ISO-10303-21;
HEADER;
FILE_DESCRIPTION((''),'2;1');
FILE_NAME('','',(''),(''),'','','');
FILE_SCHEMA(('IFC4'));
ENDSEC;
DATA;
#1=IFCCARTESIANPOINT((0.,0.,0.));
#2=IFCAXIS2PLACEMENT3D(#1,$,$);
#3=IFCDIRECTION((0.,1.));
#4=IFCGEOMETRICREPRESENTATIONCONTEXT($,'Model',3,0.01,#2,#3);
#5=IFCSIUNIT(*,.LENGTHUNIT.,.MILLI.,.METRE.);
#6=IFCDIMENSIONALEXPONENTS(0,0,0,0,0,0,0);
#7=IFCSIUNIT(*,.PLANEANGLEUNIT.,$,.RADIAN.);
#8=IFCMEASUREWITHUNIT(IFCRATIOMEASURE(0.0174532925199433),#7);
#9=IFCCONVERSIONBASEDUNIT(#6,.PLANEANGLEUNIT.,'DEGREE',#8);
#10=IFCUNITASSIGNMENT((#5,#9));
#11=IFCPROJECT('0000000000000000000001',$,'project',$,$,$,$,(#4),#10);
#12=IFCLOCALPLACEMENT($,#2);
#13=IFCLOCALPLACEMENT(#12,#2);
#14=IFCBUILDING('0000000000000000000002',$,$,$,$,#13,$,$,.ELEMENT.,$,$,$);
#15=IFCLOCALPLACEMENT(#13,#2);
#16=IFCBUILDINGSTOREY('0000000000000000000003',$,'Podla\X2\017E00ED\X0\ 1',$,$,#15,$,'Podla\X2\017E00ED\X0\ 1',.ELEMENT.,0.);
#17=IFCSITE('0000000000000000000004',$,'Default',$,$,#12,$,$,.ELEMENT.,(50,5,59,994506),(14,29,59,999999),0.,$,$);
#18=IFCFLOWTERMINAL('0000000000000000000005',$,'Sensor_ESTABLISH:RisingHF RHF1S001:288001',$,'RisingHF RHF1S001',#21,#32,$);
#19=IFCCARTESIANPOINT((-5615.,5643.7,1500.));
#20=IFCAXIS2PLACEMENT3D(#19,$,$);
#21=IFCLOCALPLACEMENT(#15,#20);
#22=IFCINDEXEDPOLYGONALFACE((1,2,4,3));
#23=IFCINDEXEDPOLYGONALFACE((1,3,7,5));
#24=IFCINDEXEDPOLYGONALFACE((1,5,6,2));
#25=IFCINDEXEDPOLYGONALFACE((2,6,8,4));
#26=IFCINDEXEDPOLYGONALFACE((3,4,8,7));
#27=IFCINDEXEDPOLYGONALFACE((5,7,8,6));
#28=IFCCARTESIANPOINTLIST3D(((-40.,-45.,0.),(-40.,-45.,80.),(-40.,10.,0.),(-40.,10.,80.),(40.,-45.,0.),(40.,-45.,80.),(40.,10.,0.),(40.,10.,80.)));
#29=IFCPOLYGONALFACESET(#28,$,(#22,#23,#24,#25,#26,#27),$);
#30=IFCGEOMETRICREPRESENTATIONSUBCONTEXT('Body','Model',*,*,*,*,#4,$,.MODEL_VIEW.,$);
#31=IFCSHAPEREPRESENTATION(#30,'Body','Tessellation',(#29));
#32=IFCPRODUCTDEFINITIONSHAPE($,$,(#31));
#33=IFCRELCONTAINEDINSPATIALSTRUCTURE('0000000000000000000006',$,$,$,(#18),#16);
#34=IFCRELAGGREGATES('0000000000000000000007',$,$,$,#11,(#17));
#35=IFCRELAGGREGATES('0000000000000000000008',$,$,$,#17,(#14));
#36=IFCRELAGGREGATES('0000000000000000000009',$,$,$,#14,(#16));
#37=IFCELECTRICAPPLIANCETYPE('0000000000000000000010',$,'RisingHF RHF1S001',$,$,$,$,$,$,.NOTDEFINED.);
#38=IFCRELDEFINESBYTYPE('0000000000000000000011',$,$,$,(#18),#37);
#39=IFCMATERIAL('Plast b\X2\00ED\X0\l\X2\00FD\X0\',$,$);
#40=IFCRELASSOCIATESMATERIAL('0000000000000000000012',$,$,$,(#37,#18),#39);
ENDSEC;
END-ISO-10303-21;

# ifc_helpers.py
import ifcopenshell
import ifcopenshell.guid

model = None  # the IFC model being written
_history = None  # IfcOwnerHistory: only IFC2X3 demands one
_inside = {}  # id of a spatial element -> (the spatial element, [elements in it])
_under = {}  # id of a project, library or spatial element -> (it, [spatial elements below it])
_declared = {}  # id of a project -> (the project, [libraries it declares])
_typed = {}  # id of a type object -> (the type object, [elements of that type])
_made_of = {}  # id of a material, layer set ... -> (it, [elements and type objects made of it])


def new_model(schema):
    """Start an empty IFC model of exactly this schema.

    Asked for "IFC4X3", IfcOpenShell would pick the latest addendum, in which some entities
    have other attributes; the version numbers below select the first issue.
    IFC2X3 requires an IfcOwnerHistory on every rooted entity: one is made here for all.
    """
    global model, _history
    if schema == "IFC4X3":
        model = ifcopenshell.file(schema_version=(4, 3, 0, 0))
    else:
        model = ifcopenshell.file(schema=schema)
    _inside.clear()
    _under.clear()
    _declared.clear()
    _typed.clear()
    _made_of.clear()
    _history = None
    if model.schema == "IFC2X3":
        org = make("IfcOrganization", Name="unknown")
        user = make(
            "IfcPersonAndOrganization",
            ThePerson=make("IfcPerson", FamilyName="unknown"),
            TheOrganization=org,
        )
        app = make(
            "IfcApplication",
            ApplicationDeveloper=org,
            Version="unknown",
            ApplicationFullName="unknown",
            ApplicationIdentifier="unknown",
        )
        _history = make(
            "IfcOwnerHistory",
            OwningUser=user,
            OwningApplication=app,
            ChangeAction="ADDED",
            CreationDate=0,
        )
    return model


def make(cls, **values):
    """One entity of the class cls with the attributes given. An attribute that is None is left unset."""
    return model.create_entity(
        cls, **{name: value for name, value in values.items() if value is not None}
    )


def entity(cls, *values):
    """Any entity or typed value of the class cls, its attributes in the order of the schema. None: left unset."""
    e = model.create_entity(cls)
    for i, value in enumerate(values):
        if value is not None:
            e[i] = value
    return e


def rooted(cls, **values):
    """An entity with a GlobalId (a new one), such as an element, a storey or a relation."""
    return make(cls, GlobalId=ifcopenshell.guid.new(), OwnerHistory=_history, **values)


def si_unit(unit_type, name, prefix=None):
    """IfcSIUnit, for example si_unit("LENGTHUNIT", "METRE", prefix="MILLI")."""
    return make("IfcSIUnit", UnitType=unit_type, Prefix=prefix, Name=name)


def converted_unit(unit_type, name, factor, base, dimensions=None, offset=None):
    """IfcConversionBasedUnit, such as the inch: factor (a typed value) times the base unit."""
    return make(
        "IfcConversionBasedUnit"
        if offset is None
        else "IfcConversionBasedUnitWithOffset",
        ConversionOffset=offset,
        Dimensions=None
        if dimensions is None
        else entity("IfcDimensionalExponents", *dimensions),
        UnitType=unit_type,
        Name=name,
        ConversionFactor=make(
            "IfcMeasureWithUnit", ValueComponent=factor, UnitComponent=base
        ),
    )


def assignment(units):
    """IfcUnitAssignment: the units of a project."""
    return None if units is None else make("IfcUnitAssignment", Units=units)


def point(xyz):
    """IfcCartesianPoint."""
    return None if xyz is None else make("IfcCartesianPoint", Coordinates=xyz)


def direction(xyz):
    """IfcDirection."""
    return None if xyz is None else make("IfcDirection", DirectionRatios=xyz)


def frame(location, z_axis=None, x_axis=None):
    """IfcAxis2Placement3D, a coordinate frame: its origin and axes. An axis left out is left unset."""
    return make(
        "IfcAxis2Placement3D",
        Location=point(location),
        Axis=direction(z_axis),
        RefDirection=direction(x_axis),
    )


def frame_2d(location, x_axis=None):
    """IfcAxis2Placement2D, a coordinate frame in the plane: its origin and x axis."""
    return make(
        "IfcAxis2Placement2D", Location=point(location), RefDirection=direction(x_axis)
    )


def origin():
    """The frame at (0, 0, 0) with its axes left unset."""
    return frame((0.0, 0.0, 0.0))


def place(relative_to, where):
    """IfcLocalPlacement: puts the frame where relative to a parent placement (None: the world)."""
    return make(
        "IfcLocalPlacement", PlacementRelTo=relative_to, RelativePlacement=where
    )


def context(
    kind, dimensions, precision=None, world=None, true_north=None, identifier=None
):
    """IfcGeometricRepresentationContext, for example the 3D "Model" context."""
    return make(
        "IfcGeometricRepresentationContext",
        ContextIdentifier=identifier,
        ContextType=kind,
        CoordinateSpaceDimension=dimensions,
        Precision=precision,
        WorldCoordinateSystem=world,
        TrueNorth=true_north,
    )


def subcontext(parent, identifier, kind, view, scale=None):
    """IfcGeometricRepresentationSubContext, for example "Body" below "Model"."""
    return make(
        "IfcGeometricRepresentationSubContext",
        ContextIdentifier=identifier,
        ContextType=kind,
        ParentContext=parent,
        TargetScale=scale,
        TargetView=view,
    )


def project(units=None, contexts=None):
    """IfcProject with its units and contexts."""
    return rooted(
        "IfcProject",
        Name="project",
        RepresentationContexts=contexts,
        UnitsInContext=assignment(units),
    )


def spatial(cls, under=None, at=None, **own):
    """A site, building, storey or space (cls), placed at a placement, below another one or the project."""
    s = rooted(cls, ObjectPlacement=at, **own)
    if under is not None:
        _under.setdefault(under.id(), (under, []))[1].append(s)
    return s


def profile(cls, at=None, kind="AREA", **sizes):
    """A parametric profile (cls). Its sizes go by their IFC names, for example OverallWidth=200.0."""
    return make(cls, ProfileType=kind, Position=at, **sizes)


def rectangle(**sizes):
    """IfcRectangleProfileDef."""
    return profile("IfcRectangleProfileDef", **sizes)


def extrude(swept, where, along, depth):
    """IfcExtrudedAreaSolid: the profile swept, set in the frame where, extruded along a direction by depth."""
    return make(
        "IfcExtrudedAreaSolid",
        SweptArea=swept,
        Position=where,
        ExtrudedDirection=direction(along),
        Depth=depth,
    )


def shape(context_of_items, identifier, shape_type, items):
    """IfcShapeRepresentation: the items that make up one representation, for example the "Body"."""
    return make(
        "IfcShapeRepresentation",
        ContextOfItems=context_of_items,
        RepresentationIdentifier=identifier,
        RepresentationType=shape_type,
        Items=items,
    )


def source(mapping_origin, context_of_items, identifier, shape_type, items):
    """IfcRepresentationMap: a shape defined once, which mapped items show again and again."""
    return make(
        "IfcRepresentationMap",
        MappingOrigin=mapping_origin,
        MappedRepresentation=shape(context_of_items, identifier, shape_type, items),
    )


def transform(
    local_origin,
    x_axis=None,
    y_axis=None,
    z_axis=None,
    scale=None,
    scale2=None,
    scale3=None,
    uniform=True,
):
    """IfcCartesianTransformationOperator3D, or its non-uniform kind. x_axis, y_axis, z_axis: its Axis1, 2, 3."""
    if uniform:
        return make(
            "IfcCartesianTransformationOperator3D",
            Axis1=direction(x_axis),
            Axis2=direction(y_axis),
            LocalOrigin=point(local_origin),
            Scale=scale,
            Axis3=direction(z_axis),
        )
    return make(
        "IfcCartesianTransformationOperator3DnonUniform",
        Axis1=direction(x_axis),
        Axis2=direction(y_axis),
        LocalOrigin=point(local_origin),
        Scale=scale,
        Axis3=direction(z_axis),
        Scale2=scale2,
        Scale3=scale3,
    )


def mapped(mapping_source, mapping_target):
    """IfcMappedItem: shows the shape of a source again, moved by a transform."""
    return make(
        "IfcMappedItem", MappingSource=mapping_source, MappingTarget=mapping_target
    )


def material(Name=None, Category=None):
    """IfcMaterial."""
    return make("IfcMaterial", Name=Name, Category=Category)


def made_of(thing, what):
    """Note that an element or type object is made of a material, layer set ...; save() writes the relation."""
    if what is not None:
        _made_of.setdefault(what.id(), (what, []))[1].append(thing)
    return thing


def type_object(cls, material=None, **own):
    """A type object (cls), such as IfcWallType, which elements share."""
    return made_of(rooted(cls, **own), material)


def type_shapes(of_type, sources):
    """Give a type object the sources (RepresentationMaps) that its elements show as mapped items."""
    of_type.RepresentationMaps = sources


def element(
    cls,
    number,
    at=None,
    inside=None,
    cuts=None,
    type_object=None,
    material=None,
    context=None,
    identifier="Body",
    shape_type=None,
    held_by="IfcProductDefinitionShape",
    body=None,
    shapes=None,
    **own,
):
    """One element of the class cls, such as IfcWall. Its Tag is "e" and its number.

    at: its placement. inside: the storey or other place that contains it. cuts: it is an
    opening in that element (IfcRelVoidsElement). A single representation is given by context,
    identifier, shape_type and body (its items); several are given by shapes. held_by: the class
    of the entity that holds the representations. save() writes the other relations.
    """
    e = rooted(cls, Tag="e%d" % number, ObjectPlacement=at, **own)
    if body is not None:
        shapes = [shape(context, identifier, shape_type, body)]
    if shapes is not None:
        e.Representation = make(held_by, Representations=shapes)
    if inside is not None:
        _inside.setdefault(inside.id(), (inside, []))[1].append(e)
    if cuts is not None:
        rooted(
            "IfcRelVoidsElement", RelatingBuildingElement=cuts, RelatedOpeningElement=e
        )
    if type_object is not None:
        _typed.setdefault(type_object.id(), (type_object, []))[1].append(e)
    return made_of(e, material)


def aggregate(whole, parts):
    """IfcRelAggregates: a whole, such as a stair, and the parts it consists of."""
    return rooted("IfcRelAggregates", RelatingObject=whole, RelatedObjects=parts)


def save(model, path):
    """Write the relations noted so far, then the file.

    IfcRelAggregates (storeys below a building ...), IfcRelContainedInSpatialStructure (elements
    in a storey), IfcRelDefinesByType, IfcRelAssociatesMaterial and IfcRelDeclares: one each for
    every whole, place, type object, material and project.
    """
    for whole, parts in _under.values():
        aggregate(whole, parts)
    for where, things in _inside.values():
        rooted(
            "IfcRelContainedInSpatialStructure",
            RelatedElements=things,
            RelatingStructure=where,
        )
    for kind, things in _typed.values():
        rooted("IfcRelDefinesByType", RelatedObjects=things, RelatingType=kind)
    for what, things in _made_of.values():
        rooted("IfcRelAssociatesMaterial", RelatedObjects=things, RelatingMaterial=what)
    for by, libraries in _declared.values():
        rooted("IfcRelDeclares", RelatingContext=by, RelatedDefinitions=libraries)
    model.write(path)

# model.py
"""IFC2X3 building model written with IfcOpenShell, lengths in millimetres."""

from ifc_helpers import new_model, entity, si_unit, converted_unit, direction, frame, frame_2d, origin, place, context, subcontext, project, spatial, rectangle, extrude, source, transform, mapped, material, type_object, type_shapes, element, save


model = new_model("IFC2X3")

# Units and contexts
model_context = context("Model", 3, precision=0.01, world=origin(), true_north=direction((0.0, 1.0)))
body_context = subcontext(model_context, "Body", "Model", "MODEL_VIEW")
ifc_project = project(units=[si_unit("LENGTHUNIT", "METRE", prefix="MILLI"), converted_unit("PLANEANGLEUNIT", "DEGREE", entity("IfcRatioMeasure", 0.0174532925199433), si_unit("PLANEANGLEUNIT", "RADIAN"), dimensions=[0, 0, 0, 0, 0, 0, 0])], contexts=[model_context])

# Site, building, storey
site_placement = place(None, origin())
site = spatial("IfcSite", under=ifc_project, at=site_placement, Name="Default", CompositionType="ELEMENT", RefLatitude=(50, 5, 59, 994506), RefLongitude=(14, 29, 59, 999999), RefElevation=0.0)
building_placement = place(site_placement, origin())
building = spatial("IfcBuilding", under=site, at=building_placement, CompositionType="ELEMENT")
storey_placement = place(building_placement, origin())
storey = spatial("IfcBuildingStorey", under=building, at=storey_placement, Name="Podlaží 1", LongName="Podlaží 1", CompositionType="ELEMENT", Elevation=0.0)

# Flow terminal
ifc_material_1 = material(Name="Plast bílý")
electric_appliance_type = type_object("IfcElectricApplianceType", Name="RisingHF RHF1S001", PredefinedType="NOTDEFINED", material=ifc_material_1)
shared_shape_1 = source(origin(), body_context, "Body", "SweptSolid", [
    extrude(rectangle(XDim=80.0, YDim=55.0, at=frame_2d((0.0, 0.0), x_axis=(1.0, 0.0))), frame((0.0, -17.5, 0.0), z_axis=(0.0, 0.0, 1.0), x_axis=(-1.0, 0.0, 0.0)), (0.0, 0.0, 1.0), 80.0),
])
type_shapes(electric_appliance_type, [shared_shape_1])
flow_terminal_placement = place(storey_placement, frame((-5615.0, 5643.7, 1500.0)))
element("IfcFlowTerminal", 1, at=flow_terminal_placement, inside=storey, type_object=electric_appliance_type, material=ifc_material_1, Name="Sensor_ESTABLISH:RisingHF RHF1S001:288001", ObjectType="RisingHF RHF1S001", context=body_context, shape_type="MappedRepresentation", body=[
    mapped(shared_shape_1, transform((0.0, 0.0, 0.0), scale=1.0)),
])

save(model, "model.ifc")
